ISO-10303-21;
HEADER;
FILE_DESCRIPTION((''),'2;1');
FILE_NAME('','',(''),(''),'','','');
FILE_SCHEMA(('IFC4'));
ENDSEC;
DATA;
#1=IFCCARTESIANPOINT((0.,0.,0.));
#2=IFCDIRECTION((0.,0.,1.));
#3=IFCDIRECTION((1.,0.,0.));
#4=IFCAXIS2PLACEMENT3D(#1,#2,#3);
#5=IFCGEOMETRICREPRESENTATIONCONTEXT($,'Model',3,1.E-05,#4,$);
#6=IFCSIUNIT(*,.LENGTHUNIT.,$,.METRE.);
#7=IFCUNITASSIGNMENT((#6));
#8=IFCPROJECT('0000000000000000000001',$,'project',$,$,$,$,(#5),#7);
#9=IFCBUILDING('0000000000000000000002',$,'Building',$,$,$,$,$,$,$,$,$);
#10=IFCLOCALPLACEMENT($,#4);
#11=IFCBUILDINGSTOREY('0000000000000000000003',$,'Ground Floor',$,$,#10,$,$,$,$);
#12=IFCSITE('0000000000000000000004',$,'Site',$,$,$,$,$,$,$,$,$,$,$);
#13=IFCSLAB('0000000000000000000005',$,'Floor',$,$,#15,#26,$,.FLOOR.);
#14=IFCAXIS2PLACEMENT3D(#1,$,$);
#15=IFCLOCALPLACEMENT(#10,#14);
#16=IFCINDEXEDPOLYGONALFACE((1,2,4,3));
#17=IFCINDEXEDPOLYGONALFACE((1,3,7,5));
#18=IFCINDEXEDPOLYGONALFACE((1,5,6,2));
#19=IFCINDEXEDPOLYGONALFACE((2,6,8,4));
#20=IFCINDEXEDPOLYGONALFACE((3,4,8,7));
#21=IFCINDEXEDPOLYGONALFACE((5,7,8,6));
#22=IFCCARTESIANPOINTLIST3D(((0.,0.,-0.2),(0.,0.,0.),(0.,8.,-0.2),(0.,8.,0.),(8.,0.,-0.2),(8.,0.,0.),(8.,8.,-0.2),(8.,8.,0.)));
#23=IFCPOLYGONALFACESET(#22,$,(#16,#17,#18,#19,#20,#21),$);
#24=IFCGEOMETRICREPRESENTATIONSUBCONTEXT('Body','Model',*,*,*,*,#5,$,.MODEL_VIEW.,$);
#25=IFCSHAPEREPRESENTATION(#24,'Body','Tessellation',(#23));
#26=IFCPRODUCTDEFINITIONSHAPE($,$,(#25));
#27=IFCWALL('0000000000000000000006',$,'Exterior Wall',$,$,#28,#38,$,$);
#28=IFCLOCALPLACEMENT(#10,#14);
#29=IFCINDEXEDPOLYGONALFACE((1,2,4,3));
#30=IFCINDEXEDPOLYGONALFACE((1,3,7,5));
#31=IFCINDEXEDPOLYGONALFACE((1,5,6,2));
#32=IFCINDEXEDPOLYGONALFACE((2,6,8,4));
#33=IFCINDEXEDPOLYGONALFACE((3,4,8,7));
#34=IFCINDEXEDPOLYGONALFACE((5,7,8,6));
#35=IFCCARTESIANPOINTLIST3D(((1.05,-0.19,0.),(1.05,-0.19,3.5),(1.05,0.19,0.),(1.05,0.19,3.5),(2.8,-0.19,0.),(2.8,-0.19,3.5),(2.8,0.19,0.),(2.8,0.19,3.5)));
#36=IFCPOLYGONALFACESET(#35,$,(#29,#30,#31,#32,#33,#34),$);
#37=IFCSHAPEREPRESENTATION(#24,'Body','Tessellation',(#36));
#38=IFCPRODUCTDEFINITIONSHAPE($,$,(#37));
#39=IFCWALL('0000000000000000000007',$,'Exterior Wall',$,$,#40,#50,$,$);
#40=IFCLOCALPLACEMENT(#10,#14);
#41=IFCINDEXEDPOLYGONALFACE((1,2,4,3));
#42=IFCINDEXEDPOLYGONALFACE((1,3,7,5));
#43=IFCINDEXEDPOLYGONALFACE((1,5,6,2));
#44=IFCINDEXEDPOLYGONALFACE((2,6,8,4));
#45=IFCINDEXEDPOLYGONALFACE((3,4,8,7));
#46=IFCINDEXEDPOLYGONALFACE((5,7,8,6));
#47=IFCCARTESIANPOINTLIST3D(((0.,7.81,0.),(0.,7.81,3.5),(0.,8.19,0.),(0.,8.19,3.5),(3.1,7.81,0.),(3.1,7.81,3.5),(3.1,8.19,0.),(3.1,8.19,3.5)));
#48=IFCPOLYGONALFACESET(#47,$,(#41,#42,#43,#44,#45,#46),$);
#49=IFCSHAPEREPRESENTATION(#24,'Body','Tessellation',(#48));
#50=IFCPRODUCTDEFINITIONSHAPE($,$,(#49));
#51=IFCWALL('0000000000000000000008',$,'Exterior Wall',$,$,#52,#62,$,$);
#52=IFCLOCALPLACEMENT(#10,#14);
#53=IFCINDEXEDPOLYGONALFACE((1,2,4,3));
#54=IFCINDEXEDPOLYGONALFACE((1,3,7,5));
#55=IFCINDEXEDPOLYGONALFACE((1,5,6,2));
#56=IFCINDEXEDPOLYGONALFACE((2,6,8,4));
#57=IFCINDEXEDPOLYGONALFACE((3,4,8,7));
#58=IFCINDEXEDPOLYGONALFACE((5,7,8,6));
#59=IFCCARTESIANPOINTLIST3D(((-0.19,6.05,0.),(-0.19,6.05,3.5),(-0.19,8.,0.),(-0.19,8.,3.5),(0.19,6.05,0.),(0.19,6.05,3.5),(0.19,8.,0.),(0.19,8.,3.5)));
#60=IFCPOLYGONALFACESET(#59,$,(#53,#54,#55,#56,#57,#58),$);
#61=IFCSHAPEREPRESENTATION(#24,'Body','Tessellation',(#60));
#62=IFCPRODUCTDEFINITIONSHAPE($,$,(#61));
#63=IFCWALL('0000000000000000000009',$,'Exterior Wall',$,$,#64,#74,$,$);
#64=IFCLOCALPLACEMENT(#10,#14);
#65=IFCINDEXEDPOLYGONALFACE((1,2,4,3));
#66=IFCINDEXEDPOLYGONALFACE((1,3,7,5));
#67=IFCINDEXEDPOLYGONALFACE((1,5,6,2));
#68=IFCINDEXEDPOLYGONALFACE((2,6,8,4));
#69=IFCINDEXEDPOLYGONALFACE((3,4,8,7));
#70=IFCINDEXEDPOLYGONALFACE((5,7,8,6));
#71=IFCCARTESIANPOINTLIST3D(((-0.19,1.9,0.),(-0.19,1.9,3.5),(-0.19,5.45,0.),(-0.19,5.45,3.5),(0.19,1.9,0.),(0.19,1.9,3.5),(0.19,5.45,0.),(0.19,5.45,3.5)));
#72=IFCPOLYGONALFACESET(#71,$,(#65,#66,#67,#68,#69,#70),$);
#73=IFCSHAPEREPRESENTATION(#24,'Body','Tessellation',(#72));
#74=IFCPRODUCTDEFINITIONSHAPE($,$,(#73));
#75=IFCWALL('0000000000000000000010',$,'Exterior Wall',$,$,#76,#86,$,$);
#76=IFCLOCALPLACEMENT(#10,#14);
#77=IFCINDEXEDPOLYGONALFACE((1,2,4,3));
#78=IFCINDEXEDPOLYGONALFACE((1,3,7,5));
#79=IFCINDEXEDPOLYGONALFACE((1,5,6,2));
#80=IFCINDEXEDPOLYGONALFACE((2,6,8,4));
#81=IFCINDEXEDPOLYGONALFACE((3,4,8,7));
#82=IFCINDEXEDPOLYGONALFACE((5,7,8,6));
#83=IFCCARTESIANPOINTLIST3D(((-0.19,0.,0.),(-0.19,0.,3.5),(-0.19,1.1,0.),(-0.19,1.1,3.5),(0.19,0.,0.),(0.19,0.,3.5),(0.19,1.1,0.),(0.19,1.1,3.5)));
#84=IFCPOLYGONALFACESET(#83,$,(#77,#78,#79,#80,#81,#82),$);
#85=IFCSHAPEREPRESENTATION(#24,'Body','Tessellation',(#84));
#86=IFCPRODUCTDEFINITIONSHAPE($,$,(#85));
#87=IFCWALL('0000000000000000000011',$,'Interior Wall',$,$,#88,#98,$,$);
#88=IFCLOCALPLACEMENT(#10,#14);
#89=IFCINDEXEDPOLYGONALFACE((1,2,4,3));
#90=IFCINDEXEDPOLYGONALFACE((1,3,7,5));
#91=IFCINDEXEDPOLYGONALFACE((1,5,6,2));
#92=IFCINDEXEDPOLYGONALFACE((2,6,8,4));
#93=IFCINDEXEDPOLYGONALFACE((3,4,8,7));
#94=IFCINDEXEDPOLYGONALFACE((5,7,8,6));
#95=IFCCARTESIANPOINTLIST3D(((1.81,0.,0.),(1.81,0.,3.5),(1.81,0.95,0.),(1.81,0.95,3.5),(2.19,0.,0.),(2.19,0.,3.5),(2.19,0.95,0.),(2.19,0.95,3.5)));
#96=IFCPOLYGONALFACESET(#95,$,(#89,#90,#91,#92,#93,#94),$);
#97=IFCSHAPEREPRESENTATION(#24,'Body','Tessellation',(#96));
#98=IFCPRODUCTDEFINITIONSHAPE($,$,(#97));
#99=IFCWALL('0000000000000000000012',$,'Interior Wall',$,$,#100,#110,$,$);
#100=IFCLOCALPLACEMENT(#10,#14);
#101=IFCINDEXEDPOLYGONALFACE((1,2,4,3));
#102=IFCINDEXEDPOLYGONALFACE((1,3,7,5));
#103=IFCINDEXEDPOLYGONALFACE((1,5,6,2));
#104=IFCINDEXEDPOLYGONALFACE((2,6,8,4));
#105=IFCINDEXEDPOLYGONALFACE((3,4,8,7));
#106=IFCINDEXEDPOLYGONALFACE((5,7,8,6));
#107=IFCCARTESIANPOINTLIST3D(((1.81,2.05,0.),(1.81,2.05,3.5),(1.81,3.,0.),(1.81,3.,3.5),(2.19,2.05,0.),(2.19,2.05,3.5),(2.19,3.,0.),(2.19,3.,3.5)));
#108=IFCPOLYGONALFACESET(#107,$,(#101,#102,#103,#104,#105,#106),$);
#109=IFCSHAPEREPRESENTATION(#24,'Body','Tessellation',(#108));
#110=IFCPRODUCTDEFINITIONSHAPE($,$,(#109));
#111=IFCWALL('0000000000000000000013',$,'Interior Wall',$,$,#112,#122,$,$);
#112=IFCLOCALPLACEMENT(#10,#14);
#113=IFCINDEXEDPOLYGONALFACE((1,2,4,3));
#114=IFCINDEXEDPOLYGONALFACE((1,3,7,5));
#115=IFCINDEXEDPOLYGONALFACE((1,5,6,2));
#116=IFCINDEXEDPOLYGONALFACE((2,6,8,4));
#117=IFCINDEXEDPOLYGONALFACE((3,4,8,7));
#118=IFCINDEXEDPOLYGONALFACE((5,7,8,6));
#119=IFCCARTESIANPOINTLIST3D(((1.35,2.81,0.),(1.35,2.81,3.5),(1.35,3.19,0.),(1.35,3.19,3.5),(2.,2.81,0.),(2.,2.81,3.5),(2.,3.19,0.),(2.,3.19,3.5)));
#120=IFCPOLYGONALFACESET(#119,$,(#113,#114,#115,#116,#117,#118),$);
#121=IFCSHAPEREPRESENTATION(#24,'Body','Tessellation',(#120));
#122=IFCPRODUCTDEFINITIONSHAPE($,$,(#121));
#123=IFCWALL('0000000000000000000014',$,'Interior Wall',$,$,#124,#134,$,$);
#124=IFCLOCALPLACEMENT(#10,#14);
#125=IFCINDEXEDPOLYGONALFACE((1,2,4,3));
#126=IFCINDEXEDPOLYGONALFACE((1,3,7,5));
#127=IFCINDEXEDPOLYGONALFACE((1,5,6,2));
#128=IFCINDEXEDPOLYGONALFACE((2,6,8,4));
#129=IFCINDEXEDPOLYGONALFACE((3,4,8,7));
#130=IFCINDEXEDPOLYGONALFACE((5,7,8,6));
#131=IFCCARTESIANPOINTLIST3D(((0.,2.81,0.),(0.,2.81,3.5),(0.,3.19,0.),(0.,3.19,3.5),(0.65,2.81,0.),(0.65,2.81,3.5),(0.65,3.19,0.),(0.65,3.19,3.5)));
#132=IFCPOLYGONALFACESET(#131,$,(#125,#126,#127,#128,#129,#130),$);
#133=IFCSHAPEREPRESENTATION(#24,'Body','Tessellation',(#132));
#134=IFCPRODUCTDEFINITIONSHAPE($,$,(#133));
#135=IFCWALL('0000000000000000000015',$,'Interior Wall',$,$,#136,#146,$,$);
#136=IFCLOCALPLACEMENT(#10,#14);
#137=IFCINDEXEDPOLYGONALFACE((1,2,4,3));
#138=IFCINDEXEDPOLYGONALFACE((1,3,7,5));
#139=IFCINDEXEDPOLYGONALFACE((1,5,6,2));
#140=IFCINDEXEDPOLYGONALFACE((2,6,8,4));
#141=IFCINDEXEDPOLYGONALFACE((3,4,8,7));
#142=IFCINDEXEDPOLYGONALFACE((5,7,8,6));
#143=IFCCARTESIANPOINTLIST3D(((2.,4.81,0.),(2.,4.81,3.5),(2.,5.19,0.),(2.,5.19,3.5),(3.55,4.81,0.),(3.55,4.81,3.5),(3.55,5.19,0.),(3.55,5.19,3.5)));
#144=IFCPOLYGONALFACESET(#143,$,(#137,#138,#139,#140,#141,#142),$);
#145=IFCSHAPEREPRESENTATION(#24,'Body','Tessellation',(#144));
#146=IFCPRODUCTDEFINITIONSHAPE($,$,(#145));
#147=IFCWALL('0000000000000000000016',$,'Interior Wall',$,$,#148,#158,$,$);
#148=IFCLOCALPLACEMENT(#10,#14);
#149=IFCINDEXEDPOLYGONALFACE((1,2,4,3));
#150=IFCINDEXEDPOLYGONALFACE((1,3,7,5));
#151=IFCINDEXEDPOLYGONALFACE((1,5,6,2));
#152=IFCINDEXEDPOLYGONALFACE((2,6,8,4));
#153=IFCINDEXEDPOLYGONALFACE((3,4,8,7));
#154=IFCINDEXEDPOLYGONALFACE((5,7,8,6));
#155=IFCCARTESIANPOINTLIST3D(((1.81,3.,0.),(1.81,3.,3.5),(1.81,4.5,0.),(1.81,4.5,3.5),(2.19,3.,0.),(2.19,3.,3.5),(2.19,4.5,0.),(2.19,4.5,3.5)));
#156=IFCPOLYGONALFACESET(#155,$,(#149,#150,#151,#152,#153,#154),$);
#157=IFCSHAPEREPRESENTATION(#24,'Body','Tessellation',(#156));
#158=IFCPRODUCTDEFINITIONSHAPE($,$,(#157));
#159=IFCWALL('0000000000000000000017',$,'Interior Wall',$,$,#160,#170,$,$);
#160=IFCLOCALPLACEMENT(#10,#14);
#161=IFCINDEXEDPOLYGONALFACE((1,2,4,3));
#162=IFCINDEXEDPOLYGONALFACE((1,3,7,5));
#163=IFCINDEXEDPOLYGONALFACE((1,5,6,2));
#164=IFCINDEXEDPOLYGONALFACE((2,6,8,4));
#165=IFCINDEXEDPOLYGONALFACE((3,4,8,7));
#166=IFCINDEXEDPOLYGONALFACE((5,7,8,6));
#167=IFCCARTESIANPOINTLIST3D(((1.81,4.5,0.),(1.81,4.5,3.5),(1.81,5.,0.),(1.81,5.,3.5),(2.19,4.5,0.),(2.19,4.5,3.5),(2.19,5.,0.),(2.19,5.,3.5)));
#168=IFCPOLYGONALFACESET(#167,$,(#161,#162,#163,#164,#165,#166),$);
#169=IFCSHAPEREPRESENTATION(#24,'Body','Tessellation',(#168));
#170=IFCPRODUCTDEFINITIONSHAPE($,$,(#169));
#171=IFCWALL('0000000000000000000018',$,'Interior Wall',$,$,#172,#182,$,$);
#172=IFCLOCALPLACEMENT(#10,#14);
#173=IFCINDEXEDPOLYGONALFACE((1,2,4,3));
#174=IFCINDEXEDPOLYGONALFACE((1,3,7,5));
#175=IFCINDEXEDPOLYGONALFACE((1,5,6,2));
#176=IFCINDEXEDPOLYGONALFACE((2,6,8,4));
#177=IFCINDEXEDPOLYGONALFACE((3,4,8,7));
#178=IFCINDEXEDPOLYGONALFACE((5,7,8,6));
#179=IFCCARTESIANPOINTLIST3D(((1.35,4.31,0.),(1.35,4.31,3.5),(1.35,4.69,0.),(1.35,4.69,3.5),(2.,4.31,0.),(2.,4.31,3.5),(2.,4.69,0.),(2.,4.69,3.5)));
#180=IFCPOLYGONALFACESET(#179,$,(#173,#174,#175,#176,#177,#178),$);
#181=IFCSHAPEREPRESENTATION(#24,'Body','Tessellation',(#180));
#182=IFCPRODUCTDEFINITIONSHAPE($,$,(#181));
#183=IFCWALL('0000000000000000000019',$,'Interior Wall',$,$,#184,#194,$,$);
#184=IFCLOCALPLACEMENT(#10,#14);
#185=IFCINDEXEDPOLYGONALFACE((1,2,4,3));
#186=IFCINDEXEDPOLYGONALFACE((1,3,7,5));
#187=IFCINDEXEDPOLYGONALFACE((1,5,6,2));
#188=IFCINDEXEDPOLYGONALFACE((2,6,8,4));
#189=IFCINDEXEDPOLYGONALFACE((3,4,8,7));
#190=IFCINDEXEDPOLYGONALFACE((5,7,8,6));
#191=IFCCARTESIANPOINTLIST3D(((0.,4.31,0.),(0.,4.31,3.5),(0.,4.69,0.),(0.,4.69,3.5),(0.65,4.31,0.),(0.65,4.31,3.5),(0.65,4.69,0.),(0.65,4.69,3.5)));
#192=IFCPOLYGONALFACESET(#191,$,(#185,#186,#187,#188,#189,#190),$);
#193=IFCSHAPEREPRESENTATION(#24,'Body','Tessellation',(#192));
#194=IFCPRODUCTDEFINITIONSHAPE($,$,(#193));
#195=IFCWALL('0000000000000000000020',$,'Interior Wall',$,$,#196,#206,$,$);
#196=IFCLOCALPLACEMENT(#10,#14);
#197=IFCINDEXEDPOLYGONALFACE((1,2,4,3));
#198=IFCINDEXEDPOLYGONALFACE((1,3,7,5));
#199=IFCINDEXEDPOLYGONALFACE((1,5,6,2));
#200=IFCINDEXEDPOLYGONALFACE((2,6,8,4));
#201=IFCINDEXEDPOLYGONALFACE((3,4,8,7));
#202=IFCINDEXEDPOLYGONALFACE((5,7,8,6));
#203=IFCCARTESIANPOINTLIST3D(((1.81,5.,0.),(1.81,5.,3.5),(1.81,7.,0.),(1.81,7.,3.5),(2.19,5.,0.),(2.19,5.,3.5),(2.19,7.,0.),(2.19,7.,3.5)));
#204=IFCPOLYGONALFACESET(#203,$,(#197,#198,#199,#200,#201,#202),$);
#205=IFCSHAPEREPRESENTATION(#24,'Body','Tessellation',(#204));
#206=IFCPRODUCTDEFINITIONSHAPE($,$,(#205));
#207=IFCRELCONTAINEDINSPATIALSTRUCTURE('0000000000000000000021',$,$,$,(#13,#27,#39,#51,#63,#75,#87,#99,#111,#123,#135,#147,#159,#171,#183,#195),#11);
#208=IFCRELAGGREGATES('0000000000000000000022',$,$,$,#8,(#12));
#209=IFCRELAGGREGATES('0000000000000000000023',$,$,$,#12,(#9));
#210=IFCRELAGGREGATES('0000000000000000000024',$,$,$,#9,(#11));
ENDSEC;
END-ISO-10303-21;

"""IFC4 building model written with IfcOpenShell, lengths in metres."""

from ifc_helpers import new_model, si_unit, frame, origin_with_axes, place, context, subcontext, project, spatial, indexed_curve, outline, extrude, element, save


model = new_model("IFC4")

# Units and contexts
model_context = context("Model", 3, precision=1e-05, world=origin_with_axes())
body_context = subcontext(model_context, "Body", "Model", "MODEL_VIEW")
ifc_project = project(units=[si_unit("LENGTHUNIT", "METRE")], contexts=[model_context])

# Site, building, storey
site = spatial("IfcSite", under=ifc_project, Name="Site")
building = spatial("IfcBuilding", under=site, Name="Building")
storey_placement = place(None, origin_with_axes())
storey = spatial("IfcBuildingStorey", under=building, at=storey_placement, Name="Ground Floor")

# Slab
slab_placement = place(storey_placement, frame((0.0, 0.0, -0.2), z_axis=(0.0, 0.0, 1.0), x_axis=(1.0, 0.0, 0.0)))
element("IfcSlab", 1, at=slab_placement, inside=storey, Name="Floor", PredefinedType="FLOOR", context=body_context, shape_type="SweptSolid", body=[
    extrude(outline(indexed_curve([(0.0, 0.0), (8.0, 0.0), (8.0, 8.0), (0.0, 8.0)])), None, (0.0, 0.0, 1.0), 0.2),
])

# Walls
wall_1_placement = place(storey_placement, frame((1.05, 0.0, 0.0), z_axis=(0.0, 0.0, 1.0), x_axis=(1.0, 0.0, 0.0)))
element("IfcWall", 2, at=wall_1_placement, inside=storey, Name="Exterior Wall", context=body_context, shape_type="SweptSolid", body=[
    extrude(outline(indexed_curve([(0.0, 0.0), (0.0, 0.38), (1.75, 0.38), (1.75, 0.0), (0.0, 0.0)], self_intersect=False)), frame((0.0, -0.19, 0.0), z_axis=(0.0, 0.0, 1.0), x_axis=(1.0, 0.0, 0.0)), (0.0, 0.0, 1.0), 3.5),
])
wall_2_placement = place(storey_placement, frame((3.1, 8.0, 0.0), z_axis=(0.0, 0.0, 1.0), x_axis=(-1.0, 0.0, 0.0)))
element("IfcWall", 3, at=wall_2_placement, inside=storey, Name="Exterior Wall", context=body_context, shape_type="SweptSolid", body=[
    extrude(outline(indexed_curve([(0.0, 0.0), (0.0, 0.38), (3.1, 0.38), (3.1, 0.0), (0.0, 0.0)], self_intersect=False)), frame((0.0, -0.19, 0.0), z_axis=(0.0, 0.0, 1.0), x_axis=(1.0, 0.0, 0.0)), (0.0, 0.0, 1.0), 3.5),
])
wall_3_placement = place(storey_placement, frame((0.0, 8.0, 0.0), z_axis=(0.0, 0.0, 1.0), x_axis=(0.0, -1.0, 0.0)))
element("IfcWall", 4, at=wall_3_placement, inside=storey, Name="Exterior Wall", context=body_context, shape_type="SweptSolid", body=[
    extrude(outline(indexed_curve([(0.0, 0.0), (0.0, 0.38), (1.95, 0.38), (1.95, 0.0), (0.0, 0.0)], self_intersect=False)), frame((0.0, -0.19, 0.0), z_axis=(0.0, 0.0, 1.0), x_axis=(1.0, 0.0, 0.0)), (0.0, 0.0, 1.0), 3.5),
])
wall_4_placement = place(storey_placement, frame((0.0, 5.45, 0.0), z_axis=(0.0, 0.0, 1.0), x_axis=(0.0, -1.0, 0.0)))
element("IfcWall", 5, at=wall_4_placement, inside=storey, Name="Exterior Wall", context=body_context, shape_type="SweptSolid", body=[
    extrude(outline(indexed_curve([(0.0, 0.0), (0.0, 0.38), (3.55, 0.38), (3.55, 0.0), (0.0, 0.0)], self_intersect=False)), frame((0.0, -0.19, 0.0), z_axis=(0.0, 0.0, 1.0), x_axis=(1.0, 0.0, 0.0)), (0.0, 0.0, 1.0), 3.5),
])
wall_5_placement = place(storey_placement, frame((0.0, 1.1, 0.0), z_axis=(0.0, 0.0, 1.0), x_axis=(0.0, -1.0, 0.0)))
element("IfcWall", 6, at=wall_5_placement, inside=storey, Name="Exterior Wall", context=body_context, shape_type="SweptSolid", body=[
    extrude(outline(indexed_curve([(0.0, 0.0), (0.0, 0.38), (1.1, 0.38), (1.1, 0.0), (0.0, 0.0)], self_intersect=False)), frame((0.0, -0.19, 0.0), z_axis=(0.0, 0.0, 1.0), x_axis=(1.0, 0.0, 0.0)), (0.0, 0.0, 1.0), 3.5),
])
wall_6_placement = place(storey_placement, frame((2.0, 0.0, 0.0), z_axis=(0.0, 0.0, 1.0), x_axis=(0.0, 1.0, 0.0)))
element("IfcWall", 7, at=wall_6_placement, inside=storey, Name="Interior Wall", context=body_context, shape_type="SweptSolid", body=[
    extrude(outline(indexed_curve([(0.0, 0.0), (0.0, 0.38), (0.95, 0.38), (0.95, 0.0), (0.0, 0.0)], self_intersect=False)), frame((0.0, -0.19, 0.0), z_axis=(0.0, 0.0, 1.0), x_axis=(1.0, 0.0, 0.0)), (0.0, 0.0, 1.0), 3.5),
])
wall_7_placement = place(storey_placement, frame((2.0, 2.05, 0.0), z_axis=(0.0, 0.0, 1.0), x_axis=(0.0, 1.0, 0.0)))
element("IfcWall", 8, at=wall_7_placement, inside=storey, Name="Interior Wall", context=body_context, shape_type="SweptSolid", body=[
    extrude(outline(indexed_curve([(0.0, 0.0), (0.0, 0.38), (0.95, 0.38), (0.95, 0.0), (0.0, 0.0)], self_intersect=False)), frame((0.0, -0.19, 0.0), z_axis=(0.0, 0.0, 1.0), x_axis=(1.0, 0.0, 0.0)), (0.0, 0.0, 1.0), 3.5),
])
for number, where, z_axis, x_axis, name in (
    (9, (2.0, 3.0, 0.0), (0.0, 0.0, 1.0), (-1.0, 0.0, 0.0), "Interior Wall"),
    (10, (0.65, 3.0, 0.0), (0.0, 0.0, 1.0), (-1.0, 0.0, 0.0), "Interior Wall"),
):
    element("IfcWall", number, at=place(storey_placement, frame(where, z_axis=z_axis, x_axis=x_axis)), inside=storey, Name=name, context=body_context, shape_type="SweptSolid", body=[
        extrude(outline(indexed_curve([(0.0, 0.0), (0.0, 0.38), (0.65, 0.38), (0.65, 0.0), (0.0, 0.0)], self_intersect=False)), frame((0.0, -0.19, 0.0), z_axis=(0.0, 0.0, 1.0), x_axis=(1.0, 0.0, 0.0)), (0.0, 0.0, 1.0), 3.5),
    ])
wall_8_placement = place(storey_placement, frame((3.55, 5.0, 0.0), z_axis=(0.0, 0.0, 1.0), x_axis=(-1.0, 0.0, 0.0)))
element("IfcWall", 11, at=wall_8_placement, inside=storey, Name="Interior Wall", context=body_context, shape_type="SweptSolid", body=[
    extrude(outline(indexed_curve([(0.0, 0.0), (0.0, 0.38), (1.55, 0.38), (1.55, 0.0), (0.0, 0.0)], self_intersect=False)), frame((0.0, -0.19, 0.0), z_axis=(0.0, 0.0, 1.0), x_axis=(1.0, 0.0, 0.0)), (0.0, 0.0, 1.0), 3.5),
])
wall_9_placement = place(storey_placement, frame((2.0, 4.5, 0.0), z_axis=(0.0, 0.0, 1.0), x_axis=(0.0, -1.0, 0.0)))
element("IfcWall", 12, at=wall_9_placement, inside=storey, Name="Interior Wall", context=body_context, shape_type="SweptSolid", body=[
    extrude(outline(indexed_curve([(0.0, 0.0), (0.0, 0.38), (1.5, 0.38), (1.5, 0.0), (0.0, 0.0)], self_intersect=False)), frame((0.0, -0.19, 0.0), z_axis=(0.0, 0.0, 1.0), x_axis=(1.0, 0.0, 0.0)), (0.0, 0.0, 1.0), 3.5),
])
wall_10_placement = place(storey_placement, frame((2.0, 5.0, 0.0), z_axis=(0.0, 0.0, 1.0), x_axis=(0.0, -1.0, 0.0)))
element("IfcWall", 13, at=wall_10_placement, inside=storey, Name="Interior Wall", context=body_context, shape_type="SweptSolid", body=[
    extrude(outline(indexed_curve([(0.0, 0.0), (0.0, 0.38), (0.5, 0.38), (0.5, 0.0), (0.0, 0.0)], self_intersect=False)), frame((0.0, -0.19, 0.0), z_axis=(0.0, 0.0, 1.0), x_axis=(1.0, 0.0, 0.0)), (0.0, 0.0, 1.0), 3.5),
])
for number, where, z_axis, x_axis, name in (
    (14, (2.0, 4.5, 0.0), (0.0, 0.0, 1.0), (-1.0, 0.0, 0.0), "Interior Wall"),
    (15, (0.65, 4.5, 0.0), (0.0, 0.0, 1.0), (-1.0, 0.0, 0.0), "Interior Wall"),
):
    element("IfcWall", number, at=place(storey_placement, frame(where, z_axis=z_axis, x_axis=x_axis)), inside=storey, Name=name, context=body_context, shape_type="SweptSolid", body=[
        extrude(outline(indexed_curve([(0.0, 0.0), (0.0, 0.38), (0.65, 0.38), (0.65, 0.0), (0.0, 0.0)], self_intersect=False)), frame((0.0, -0.19, 0.0), z_axis=(0.0, 0.0, 1.0), x_axis=(1.0, 0.0, 0.0)), (0.0, 0.0, 1.0), 3.5),
    ])
wall_11_placement = place(storey_placement, frame((2.0, 5.0, 0.0), z_axis=(0.0, 0.0, 1.0), x_axis=(0.0, 1.0, 0.0)))
element("IfcWall", 16, at=wall_11_placement, inside=storey, Name="Interior Wall", context=body_context, shape_type="SweptSolid", body=[
    extrude(outline(indexed_curve([(0.0, 0.0), (0.0, 0.38), (2.0, 0.38), (2.0, 0.0), (0.0, 0.0)], self_intersect=False)), frame((0.0, -0.19, 0.0), z_axis=(0.0, 0.0, 1.0), x_axis=(1.0, 0.0, 0.0)), (0.0, 0.0, 1.0), 3.5),
])

save(model, "model.ifc")
